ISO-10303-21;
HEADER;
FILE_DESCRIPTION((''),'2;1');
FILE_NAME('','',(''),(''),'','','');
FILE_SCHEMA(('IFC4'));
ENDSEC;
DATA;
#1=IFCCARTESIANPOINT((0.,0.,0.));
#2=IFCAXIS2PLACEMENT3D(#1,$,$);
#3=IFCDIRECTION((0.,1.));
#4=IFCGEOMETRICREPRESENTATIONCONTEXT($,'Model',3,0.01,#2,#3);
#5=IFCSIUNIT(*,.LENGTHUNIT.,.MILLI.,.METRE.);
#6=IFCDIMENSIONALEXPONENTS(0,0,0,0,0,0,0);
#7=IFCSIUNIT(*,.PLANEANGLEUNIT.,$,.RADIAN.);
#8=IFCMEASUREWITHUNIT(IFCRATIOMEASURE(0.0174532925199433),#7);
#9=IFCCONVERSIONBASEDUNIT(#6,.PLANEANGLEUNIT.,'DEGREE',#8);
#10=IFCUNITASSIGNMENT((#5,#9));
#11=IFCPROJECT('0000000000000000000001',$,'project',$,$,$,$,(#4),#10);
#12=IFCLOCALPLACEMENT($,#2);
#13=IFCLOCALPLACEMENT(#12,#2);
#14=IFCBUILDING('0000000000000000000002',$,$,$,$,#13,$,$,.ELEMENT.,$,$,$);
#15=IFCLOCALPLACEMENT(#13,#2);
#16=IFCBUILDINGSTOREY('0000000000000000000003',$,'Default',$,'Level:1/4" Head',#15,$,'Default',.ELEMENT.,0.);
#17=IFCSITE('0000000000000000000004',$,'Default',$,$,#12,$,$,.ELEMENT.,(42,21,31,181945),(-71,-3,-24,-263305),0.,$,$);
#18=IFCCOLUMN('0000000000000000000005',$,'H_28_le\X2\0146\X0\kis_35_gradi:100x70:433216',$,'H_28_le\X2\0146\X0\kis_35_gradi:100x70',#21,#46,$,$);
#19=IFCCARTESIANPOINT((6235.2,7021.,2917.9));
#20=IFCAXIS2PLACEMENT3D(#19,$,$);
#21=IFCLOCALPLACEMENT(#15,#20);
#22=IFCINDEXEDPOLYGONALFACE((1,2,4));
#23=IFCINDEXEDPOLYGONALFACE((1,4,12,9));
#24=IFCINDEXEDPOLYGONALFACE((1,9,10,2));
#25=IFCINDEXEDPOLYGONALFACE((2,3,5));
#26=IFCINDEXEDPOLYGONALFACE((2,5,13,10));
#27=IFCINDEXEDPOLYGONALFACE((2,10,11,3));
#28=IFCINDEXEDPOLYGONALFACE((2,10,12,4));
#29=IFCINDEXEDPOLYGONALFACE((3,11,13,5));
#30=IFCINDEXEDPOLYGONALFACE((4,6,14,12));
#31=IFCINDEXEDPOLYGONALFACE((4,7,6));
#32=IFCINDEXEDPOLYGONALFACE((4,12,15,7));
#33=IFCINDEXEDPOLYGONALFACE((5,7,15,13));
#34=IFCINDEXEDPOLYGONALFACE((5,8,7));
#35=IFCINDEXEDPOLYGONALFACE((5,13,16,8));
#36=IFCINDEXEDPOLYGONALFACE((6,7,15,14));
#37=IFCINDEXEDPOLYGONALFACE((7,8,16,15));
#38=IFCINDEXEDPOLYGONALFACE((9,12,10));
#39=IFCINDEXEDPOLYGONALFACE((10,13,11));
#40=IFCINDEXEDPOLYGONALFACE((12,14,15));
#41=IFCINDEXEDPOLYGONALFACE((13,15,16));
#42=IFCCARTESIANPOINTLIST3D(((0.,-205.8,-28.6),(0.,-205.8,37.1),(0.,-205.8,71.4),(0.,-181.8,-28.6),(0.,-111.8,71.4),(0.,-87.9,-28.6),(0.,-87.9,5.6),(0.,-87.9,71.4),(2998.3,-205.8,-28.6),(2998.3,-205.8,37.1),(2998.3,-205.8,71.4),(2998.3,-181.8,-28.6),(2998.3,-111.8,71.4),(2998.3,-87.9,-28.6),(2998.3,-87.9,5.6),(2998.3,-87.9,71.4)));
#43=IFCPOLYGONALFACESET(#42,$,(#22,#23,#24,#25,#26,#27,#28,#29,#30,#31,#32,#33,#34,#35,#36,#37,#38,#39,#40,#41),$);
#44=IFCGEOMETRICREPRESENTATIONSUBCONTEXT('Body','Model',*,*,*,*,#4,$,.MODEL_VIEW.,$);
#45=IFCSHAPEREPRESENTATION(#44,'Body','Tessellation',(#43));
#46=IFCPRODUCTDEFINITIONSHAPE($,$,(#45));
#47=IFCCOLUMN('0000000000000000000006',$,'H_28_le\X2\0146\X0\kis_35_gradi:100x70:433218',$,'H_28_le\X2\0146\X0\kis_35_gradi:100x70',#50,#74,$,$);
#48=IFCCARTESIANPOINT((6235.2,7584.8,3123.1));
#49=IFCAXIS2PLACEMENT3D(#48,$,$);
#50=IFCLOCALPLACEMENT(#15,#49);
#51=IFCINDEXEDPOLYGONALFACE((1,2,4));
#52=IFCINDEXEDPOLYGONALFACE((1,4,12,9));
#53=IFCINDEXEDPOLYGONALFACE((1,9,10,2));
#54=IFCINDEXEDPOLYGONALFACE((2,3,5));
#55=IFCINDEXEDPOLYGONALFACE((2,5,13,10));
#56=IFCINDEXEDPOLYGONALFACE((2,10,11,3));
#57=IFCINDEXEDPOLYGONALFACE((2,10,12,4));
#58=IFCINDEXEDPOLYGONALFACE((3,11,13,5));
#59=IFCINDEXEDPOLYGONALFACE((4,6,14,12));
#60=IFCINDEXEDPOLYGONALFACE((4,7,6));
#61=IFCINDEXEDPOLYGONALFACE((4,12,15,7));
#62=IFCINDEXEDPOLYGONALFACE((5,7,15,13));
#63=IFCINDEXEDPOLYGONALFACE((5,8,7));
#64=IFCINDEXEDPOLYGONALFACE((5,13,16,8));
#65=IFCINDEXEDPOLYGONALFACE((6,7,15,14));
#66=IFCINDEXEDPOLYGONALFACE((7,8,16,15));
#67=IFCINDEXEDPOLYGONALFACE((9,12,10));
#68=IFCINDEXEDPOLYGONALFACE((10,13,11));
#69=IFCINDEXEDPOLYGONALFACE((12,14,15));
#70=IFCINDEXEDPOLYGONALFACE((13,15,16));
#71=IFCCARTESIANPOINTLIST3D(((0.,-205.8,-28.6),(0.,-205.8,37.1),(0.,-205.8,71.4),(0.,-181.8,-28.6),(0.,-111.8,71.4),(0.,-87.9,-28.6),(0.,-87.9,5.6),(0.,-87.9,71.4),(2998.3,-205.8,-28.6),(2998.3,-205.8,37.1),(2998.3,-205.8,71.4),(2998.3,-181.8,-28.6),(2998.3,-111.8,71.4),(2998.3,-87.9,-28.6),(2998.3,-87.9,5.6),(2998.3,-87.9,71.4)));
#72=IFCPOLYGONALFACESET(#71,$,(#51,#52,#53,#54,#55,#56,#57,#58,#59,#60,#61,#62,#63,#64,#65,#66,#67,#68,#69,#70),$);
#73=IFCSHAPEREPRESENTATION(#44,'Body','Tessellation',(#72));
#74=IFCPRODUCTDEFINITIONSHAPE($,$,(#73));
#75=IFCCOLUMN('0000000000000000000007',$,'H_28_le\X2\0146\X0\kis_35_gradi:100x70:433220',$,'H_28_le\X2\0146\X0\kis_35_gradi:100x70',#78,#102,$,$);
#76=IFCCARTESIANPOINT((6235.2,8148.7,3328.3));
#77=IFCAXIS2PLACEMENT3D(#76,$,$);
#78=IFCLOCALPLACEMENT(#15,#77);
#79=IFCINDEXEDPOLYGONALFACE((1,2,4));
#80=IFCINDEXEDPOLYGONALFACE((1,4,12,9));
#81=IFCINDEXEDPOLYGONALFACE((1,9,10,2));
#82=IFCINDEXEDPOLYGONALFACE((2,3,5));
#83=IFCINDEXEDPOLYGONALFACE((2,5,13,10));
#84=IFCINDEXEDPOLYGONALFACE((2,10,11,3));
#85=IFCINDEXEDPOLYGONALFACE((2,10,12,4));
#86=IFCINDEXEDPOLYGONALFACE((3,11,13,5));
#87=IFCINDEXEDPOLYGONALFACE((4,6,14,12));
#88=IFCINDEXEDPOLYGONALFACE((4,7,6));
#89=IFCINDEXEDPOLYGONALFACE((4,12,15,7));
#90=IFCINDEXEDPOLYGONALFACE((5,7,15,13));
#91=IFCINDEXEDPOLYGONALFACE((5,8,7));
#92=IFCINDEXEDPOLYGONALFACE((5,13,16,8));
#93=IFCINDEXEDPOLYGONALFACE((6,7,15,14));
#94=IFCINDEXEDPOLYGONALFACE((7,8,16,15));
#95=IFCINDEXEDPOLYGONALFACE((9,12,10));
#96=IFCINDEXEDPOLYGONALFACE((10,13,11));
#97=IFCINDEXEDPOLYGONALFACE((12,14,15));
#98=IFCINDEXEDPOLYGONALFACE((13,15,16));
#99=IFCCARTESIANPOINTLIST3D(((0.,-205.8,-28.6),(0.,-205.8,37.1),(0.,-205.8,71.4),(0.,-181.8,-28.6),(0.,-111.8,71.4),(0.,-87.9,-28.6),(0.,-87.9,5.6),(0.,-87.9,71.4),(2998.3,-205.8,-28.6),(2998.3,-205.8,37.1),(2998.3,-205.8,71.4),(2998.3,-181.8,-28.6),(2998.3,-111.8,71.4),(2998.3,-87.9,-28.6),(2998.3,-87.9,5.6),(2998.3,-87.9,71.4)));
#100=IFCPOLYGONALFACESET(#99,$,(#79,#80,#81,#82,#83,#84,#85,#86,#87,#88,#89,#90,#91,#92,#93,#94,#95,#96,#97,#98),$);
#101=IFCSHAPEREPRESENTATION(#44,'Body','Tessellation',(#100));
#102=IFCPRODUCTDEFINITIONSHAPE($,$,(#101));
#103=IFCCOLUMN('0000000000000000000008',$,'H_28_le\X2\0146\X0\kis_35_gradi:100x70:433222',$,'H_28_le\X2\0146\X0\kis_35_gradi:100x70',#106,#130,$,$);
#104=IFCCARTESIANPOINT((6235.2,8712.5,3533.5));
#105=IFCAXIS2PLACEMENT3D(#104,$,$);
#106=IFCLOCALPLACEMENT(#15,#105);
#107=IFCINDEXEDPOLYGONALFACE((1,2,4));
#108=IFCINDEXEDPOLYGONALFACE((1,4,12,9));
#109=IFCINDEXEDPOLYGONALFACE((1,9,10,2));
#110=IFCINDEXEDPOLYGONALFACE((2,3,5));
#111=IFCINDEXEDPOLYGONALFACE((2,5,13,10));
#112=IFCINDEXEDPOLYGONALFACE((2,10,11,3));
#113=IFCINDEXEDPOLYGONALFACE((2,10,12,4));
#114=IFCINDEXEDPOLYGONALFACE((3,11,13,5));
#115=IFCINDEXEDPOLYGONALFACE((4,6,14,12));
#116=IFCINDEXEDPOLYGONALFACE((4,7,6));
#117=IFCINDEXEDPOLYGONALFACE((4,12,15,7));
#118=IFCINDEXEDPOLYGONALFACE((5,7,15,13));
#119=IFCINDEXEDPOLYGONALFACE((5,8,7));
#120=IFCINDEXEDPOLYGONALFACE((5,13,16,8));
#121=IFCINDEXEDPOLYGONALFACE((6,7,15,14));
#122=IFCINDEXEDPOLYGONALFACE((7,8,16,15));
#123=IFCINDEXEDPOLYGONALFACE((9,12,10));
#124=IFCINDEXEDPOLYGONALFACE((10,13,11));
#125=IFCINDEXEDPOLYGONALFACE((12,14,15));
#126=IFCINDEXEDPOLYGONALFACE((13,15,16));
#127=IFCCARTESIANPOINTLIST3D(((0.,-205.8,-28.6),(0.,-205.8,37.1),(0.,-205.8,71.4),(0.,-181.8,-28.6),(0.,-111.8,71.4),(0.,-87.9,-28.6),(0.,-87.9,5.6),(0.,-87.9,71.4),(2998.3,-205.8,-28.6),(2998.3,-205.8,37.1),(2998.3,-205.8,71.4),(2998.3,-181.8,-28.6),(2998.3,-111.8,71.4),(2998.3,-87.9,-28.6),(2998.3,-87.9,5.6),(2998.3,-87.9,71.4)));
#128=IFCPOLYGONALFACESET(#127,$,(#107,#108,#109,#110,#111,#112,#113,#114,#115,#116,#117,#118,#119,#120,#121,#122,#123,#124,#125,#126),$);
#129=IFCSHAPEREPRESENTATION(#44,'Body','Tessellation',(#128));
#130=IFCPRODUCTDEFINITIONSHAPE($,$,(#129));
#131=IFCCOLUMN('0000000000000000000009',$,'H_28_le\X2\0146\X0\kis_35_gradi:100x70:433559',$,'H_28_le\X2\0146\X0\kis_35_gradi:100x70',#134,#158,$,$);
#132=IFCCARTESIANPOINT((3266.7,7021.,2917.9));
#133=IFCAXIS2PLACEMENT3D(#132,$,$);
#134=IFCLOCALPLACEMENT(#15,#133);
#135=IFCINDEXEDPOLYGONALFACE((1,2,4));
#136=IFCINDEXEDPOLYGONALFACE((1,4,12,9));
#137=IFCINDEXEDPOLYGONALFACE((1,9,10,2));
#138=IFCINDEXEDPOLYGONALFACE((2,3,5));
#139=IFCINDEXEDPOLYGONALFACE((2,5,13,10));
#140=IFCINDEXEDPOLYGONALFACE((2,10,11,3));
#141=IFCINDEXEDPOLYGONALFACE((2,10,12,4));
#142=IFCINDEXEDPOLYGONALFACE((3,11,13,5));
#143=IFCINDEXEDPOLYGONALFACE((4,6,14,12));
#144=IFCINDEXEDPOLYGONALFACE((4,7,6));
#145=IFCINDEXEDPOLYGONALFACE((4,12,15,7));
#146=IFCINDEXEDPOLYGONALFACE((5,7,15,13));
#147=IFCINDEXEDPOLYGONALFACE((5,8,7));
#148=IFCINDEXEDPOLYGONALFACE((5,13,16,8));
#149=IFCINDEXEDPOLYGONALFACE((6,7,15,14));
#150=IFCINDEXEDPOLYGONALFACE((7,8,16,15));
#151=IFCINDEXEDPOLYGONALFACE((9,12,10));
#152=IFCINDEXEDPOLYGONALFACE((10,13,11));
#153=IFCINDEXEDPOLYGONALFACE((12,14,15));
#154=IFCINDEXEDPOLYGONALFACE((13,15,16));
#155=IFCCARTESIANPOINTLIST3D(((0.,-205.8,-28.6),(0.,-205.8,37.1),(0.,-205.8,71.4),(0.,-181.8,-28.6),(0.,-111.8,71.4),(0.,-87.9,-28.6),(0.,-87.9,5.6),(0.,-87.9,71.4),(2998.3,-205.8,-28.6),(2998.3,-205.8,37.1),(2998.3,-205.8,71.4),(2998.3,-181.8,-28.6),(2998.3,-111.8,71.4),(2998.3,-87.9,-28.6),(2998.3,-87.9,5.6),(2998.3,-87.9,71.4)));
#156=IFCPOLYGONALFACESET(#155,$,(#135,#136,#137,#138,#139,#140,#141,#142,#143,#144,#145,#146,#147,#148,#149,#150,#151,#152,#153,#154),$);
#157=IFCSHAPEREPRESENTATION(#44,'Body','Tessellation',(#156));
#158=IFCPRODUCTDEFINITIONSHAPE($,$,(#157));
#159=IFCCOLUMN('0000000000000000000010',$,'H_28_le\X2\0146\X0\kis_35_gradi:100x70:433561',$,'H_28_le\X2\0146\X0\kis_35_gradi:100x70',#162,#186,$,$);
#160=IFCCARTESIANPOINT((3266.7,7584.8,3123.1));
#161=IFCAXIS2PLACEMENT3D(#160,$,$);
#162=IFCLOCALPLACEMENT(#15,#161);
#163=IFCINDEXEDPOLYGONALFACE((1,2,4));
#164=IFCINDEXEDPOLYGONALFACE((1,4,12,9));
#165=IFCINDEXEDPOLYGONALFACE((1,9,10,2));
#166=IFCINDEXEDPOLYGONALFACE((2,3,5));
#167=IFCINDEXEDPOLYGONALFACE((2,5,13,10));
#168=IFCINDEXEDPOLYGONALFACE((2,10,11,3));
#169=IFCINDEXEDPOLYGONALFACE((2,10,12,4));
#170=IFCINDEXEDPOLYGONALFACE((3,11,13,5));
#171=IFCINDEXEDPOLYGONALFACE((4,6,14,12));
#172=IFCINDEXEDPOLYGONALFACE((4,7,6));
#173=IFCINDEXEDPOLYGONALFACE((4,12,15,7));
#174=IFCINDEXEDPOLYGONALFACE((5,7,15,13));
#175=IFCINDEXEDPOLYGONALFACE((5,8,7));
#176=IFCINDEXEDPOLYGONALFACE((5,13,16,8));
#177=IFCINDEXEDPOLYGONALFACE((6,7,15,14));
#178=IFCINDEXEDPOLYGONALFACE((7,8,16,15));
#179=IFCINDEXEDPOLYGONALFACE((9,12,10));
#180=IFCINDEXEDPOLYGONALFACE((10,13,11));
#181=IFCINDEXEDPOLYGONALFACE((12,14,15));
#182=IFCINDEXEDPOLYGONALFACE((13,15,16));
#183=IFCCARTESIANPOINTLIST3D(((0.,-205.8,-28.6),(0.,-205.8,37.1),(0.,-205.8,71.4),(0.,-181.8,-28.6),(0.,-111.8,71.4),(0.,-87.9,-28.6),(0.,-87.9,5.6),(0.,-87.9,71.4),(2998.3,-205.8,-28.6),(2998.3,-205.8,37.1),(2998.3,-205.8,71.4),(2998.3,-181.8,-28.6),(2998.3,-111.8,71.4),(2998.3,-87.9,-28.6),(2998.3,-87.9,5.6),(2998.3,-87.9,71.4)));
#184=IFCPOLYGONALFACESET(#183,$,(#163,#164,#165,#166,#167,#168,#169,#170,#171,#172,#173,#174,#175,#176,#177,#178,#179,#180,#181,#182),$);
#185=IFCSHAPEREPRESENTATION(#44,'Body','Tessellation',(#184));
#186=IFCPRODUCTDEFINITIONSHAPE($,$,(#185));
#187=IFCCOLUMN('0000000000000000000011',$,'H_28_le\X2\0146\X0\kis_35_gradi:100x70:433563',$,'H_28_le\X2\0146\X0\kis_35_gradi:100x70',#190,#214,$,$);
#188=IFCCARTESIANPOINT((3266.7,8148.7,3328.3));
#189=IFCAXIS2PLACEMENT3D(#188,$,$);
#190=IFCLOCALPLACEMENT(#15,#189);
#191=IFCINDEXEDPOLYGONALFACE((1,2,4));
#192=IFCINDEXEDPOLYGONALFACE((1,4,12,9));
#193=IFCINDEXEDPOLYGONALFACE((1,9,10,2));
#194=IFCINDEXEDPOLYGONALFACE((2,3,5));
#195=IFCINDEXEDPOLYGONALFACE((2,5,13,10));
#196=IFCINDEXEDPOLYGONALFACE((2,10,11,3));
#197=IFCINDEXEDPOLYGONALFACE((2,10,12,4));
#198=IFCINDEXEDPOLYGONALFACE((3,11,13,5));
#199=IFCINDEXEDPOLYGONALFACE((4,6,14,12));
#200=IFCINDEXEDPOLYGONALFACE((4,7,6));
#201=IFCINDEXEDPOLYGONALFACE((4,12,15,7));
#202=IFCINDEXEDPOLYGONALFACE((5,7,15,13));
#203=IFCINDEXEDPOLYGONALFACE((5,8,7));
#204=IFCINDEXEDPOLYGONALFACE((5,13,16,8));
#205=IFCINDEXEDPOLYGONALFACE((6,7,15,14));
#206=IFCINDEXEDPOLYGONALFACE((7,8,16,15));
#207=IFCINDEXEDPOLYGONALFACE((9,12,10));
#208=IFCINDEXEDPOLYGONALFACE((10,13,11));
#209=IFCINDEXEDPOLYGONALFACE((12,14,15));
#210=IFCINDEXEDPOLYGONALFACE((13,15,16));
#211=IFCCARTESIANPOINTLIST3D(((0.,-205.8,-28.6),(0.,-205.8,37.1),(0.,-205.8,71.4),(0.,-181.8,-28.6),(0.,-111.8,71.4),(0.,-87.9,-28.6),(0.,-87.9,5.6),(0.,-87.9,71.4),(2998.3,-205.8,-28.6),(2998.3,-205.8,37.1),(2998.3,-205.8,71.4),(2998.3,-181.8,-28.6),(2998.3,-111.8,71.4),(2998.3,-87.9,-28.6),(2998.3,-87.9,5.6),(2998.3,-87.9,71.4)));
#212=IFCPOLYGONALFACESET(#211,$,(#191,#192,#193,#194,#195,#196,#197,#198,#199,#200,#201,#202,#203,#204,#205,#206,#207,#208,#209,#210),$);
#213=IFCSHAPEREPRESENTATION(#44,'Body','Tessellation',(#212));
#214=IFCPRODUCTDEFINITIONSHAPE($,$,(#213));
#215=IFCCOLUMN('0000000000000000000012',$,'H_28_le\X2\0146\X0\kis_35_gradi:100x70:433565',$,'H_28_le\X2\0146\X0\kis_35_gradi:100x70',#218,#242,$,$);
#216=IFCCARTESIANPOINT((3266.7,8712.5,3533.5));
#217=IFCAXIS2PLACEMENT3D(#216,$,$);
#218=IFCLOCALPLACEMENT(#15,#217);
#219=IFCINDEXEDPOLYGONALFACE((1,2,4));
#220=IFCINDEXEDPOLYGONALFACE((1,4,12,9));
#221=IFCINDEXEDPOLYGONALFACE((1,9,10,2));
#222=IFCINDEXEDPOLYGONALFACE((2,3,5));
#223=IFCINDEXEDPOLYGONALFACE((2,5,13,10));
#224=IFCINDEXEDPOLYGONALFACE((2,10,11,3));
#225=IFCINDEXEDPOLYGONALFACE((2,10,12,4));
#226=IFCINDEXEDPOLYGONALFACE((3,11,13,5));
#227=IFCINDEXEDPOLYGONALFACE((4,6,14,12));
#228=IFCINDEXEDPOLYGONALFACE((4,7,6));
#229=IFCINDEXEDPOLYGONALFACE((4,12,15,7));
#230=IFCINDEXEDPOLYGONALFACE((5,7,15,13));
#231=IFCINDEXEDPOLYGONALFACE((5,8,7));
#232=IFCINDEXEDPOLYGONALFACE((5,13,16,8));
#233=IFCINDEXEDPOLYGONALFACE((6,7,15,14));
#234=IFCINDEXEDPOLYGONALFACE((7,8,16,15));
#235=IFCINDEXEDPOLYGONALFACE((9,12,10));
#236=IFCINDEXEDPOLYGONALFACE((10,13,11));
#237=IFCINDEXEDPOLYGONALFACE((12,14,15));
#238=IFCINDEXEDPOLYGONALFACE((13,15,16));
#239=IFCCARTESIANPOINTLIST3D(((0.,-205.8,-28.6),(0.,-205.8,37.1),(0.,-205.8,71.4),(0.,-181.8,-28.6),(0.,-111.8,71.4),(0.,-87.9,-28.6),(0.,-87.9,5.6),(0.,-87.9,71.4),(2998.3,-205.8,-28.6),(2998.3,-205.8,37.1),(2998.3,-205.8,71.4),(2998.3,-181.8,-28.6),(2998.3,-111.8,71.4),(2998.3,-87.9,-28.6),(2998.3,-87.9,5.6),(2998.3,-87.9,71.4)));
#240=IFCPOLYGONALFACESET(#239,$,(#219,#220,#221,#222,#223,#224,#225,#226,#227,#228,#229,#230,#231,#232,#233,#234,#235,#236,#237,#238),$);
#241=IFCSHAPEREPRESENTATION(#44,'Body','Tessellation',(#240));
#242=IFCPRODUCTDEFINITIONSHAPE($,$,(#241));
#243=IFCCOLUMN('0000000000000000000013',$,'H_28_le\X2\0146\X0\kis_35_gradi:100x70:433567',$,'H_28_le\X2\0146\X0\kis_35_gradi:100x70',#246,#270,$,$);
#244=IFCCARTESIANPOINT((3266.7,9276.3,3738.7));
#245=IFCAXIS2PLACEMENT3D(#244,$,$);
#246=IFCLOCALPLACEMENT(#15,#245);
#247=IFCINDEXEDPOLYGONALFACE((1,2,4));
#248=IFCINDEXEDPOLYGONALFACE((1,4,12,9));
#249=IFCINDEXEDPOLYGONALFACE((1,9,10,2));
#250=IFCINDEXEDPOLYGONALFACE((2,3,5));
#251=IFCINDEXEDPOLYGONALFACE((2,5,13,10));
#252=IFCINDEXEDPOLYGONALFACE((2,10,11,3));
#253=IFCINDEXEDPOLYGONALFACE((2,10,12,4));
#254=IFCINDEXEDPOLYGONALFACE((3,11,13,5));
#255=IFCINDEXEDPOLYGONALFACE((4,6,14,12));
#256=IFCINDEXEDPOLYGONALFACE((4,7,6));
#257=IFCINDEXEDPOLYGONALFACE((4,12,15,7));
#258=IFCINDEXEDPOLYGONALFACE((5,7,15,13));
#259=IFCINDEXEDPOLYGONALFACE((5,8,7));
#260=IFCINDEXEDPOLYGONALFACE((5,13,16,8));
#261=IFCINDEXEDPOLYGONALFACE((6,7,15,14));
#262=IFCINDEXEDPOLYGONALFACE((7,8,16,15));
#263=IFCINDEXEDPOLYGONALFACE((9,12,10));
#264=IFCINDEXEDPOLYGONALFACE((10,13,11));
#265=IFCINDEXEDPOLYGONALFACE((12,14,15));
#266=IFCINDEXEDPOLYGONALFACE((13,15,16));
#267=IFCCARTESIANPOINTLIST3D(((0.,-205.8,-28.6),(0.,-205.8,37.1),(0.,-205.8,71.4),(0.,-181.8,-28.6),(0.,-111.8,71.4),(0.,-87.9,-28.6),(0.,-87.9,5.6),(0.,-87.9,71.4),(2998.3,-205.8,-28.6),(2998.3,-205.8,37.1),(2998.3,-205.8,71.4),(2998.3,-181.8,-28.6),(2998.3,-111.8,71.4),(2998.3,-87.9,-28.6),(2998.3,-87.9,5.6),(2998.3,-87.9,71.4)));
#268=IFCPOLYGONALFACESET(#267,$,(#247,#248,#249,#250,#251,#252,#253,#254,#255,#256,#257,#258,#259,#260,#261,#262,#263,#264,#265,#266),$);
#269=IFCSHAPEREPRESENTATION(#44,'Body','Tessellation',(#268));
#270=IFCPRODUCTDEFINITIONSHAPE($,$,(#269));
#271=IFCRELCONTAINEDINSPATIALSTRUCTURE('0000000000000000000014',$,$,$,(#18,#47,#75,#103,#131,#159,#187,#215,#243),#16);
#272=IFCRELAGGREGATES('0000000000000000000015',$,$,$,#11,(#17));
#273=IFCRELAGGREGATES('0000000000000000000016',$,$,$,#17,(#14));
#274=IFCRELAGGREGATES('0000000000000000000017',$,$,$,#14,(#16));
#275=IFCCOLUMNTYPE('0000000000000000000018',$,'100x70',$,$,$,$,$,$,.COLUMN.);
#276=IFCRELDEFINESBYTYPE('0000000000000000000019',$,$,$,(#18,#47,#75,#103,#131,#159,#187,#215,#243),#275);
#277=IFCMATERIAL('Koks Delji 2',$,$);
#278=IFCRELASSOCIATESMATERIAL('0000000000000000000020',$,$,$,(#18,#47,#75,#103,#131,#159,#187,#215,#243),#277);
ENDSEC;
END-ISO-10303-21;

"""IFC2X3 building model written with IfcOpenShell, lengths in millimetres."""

from ifc_helpers import new_model, entity, si_unit, converted_unit, direction, frame, frame_2d, origin, place, context, subcontext, project, spatial, rectangle, extrude, boolean, source, transform, mapped, material, type_object, type_shapes, element, save


model = new_model("IFC2X3")

# Units and contexts
model_context = context("Model", 3, precision=0.01, world=origin(), true_north=direction((0.0, 1.0)))
body_context = subcontext(model_context, "Body", "Model", "MODEL_VIEW")
ifc_project = project(units=[si_unit("LENGTHUNIT", "METRE", prefix="MILLI"), converted_unit("PLANEANGLEUNIT", "DEGREE", entity("IfcRatioMeasure", 0.0174532925199433), si_unit("PLANEANGLEUNIT", "RADIAN"), dimensions=[0, 0, 0, 0, 0, 0, 0])], contexts=[model_context])

# Site, building, storey
site_placement = place(None, origin())
site = spatial("IfcSite", under=ifc_project, at=site_placement, Name="Default", CompositionType="ELEMENT", RefLatitude=(42, 21, 31, 181945), RefLongitude=(-71, -3, -24, -263305), RefElevation=0.0)
building_placement = place(site_placement, origin())
building = spatial("IfcBuilding", under=site, at=building_placement, CompositionType="ELEMENT")
storey_placement = place(building_placement, origin())
storey = spatial("IfcBuildingStorey", under=building, at=storey_placement, Name="Default", ObjectType="Level:1/4\" Head", LongName="Default", CompositionType="ELEMENT", Elevation=0.0)

# Columns
ifc_material_1 = material(Name="Koks Delji 2")
column_type = type_object("IfcColumnType", Name="100x70", PredefinedType="COLUMN")
shared_shape_1 = source(origin(), body_context, "Body", "CSG", [
    boolean("DIFFERENCE", extrude(rectangle(XDim=2998.3, YDim=117.9, at=frame_2d((0.0, 0.0), x_axis=(1.0, 0.0))), frame((1499.1, -146.8, -28.6)), (0.0, 0.0, 1.0), 100.0), extrude(rectangle(XDim=70.0, YDim=100.0, at=frame_2d((0.0, 0.0), x_axis=(0.0, 1.0))), frame((0.0, -146.8, 21.4), z_axis=(-1.0, 0.0, 0.0), x_axis=(0.0, -0.939693, -0.34202)), (0.0, 0.0, -1.0), 2998.3)),
])
type_shapes(column_type, [shared_shape_1])
for number, where, name in (
    (1, (6235.2, 7021.0, 2917.9), "H_28_leņkis_35_gradi:100x70:433216"),
    (2, (6235.2, 7584.8, 3123.1), "H_28_leņkis_35_gradi:100x70:433218"),
    (3, (6235.2, 8148.7, 3328.3), "H_28_leņkis_35_gradi:100x70:433220"),
    (4, (6235.2, 8712.5, 3533.5), "H_28_leņkis_35_gradi:100x70:433222"),
    (5, (3266.7, 7021.0, 2917.9), "H_28_leņkis_35_gradi:100x70:433559"),
    (6, (3266.7, 7584.8, 3123.1), "H_28_leņkis_35_gradi:100x70:433561"),
    (7, (3266.7, 8148.7, 3328.3), "H_28_leņkis_35_gradi:100x70:433563"),
    (8, (3266.7, 8712.5, 3533.5), "H_28_leņkis_35_gradi:100x70:433565"),
    (9, (3266.7, 9276.3, 3738.7), "H_28_leņkis_35_gradi:100x70:433567"),
):
    element("IfcColumn", number, at=place(storey_placement, frame(where)), inside=storey, type_object=column_type, material=ifc_material_1, Name=name, ObjectType="H_28_leņkis_35_gradi:100x70", context=body_context, shape_type="MappedRepresentation", body=[
        mapped(shared_shape_1, transform((0.0, 0.0, 0.0), scale=1.0)),
    ])

save(model, "model.ifc")
